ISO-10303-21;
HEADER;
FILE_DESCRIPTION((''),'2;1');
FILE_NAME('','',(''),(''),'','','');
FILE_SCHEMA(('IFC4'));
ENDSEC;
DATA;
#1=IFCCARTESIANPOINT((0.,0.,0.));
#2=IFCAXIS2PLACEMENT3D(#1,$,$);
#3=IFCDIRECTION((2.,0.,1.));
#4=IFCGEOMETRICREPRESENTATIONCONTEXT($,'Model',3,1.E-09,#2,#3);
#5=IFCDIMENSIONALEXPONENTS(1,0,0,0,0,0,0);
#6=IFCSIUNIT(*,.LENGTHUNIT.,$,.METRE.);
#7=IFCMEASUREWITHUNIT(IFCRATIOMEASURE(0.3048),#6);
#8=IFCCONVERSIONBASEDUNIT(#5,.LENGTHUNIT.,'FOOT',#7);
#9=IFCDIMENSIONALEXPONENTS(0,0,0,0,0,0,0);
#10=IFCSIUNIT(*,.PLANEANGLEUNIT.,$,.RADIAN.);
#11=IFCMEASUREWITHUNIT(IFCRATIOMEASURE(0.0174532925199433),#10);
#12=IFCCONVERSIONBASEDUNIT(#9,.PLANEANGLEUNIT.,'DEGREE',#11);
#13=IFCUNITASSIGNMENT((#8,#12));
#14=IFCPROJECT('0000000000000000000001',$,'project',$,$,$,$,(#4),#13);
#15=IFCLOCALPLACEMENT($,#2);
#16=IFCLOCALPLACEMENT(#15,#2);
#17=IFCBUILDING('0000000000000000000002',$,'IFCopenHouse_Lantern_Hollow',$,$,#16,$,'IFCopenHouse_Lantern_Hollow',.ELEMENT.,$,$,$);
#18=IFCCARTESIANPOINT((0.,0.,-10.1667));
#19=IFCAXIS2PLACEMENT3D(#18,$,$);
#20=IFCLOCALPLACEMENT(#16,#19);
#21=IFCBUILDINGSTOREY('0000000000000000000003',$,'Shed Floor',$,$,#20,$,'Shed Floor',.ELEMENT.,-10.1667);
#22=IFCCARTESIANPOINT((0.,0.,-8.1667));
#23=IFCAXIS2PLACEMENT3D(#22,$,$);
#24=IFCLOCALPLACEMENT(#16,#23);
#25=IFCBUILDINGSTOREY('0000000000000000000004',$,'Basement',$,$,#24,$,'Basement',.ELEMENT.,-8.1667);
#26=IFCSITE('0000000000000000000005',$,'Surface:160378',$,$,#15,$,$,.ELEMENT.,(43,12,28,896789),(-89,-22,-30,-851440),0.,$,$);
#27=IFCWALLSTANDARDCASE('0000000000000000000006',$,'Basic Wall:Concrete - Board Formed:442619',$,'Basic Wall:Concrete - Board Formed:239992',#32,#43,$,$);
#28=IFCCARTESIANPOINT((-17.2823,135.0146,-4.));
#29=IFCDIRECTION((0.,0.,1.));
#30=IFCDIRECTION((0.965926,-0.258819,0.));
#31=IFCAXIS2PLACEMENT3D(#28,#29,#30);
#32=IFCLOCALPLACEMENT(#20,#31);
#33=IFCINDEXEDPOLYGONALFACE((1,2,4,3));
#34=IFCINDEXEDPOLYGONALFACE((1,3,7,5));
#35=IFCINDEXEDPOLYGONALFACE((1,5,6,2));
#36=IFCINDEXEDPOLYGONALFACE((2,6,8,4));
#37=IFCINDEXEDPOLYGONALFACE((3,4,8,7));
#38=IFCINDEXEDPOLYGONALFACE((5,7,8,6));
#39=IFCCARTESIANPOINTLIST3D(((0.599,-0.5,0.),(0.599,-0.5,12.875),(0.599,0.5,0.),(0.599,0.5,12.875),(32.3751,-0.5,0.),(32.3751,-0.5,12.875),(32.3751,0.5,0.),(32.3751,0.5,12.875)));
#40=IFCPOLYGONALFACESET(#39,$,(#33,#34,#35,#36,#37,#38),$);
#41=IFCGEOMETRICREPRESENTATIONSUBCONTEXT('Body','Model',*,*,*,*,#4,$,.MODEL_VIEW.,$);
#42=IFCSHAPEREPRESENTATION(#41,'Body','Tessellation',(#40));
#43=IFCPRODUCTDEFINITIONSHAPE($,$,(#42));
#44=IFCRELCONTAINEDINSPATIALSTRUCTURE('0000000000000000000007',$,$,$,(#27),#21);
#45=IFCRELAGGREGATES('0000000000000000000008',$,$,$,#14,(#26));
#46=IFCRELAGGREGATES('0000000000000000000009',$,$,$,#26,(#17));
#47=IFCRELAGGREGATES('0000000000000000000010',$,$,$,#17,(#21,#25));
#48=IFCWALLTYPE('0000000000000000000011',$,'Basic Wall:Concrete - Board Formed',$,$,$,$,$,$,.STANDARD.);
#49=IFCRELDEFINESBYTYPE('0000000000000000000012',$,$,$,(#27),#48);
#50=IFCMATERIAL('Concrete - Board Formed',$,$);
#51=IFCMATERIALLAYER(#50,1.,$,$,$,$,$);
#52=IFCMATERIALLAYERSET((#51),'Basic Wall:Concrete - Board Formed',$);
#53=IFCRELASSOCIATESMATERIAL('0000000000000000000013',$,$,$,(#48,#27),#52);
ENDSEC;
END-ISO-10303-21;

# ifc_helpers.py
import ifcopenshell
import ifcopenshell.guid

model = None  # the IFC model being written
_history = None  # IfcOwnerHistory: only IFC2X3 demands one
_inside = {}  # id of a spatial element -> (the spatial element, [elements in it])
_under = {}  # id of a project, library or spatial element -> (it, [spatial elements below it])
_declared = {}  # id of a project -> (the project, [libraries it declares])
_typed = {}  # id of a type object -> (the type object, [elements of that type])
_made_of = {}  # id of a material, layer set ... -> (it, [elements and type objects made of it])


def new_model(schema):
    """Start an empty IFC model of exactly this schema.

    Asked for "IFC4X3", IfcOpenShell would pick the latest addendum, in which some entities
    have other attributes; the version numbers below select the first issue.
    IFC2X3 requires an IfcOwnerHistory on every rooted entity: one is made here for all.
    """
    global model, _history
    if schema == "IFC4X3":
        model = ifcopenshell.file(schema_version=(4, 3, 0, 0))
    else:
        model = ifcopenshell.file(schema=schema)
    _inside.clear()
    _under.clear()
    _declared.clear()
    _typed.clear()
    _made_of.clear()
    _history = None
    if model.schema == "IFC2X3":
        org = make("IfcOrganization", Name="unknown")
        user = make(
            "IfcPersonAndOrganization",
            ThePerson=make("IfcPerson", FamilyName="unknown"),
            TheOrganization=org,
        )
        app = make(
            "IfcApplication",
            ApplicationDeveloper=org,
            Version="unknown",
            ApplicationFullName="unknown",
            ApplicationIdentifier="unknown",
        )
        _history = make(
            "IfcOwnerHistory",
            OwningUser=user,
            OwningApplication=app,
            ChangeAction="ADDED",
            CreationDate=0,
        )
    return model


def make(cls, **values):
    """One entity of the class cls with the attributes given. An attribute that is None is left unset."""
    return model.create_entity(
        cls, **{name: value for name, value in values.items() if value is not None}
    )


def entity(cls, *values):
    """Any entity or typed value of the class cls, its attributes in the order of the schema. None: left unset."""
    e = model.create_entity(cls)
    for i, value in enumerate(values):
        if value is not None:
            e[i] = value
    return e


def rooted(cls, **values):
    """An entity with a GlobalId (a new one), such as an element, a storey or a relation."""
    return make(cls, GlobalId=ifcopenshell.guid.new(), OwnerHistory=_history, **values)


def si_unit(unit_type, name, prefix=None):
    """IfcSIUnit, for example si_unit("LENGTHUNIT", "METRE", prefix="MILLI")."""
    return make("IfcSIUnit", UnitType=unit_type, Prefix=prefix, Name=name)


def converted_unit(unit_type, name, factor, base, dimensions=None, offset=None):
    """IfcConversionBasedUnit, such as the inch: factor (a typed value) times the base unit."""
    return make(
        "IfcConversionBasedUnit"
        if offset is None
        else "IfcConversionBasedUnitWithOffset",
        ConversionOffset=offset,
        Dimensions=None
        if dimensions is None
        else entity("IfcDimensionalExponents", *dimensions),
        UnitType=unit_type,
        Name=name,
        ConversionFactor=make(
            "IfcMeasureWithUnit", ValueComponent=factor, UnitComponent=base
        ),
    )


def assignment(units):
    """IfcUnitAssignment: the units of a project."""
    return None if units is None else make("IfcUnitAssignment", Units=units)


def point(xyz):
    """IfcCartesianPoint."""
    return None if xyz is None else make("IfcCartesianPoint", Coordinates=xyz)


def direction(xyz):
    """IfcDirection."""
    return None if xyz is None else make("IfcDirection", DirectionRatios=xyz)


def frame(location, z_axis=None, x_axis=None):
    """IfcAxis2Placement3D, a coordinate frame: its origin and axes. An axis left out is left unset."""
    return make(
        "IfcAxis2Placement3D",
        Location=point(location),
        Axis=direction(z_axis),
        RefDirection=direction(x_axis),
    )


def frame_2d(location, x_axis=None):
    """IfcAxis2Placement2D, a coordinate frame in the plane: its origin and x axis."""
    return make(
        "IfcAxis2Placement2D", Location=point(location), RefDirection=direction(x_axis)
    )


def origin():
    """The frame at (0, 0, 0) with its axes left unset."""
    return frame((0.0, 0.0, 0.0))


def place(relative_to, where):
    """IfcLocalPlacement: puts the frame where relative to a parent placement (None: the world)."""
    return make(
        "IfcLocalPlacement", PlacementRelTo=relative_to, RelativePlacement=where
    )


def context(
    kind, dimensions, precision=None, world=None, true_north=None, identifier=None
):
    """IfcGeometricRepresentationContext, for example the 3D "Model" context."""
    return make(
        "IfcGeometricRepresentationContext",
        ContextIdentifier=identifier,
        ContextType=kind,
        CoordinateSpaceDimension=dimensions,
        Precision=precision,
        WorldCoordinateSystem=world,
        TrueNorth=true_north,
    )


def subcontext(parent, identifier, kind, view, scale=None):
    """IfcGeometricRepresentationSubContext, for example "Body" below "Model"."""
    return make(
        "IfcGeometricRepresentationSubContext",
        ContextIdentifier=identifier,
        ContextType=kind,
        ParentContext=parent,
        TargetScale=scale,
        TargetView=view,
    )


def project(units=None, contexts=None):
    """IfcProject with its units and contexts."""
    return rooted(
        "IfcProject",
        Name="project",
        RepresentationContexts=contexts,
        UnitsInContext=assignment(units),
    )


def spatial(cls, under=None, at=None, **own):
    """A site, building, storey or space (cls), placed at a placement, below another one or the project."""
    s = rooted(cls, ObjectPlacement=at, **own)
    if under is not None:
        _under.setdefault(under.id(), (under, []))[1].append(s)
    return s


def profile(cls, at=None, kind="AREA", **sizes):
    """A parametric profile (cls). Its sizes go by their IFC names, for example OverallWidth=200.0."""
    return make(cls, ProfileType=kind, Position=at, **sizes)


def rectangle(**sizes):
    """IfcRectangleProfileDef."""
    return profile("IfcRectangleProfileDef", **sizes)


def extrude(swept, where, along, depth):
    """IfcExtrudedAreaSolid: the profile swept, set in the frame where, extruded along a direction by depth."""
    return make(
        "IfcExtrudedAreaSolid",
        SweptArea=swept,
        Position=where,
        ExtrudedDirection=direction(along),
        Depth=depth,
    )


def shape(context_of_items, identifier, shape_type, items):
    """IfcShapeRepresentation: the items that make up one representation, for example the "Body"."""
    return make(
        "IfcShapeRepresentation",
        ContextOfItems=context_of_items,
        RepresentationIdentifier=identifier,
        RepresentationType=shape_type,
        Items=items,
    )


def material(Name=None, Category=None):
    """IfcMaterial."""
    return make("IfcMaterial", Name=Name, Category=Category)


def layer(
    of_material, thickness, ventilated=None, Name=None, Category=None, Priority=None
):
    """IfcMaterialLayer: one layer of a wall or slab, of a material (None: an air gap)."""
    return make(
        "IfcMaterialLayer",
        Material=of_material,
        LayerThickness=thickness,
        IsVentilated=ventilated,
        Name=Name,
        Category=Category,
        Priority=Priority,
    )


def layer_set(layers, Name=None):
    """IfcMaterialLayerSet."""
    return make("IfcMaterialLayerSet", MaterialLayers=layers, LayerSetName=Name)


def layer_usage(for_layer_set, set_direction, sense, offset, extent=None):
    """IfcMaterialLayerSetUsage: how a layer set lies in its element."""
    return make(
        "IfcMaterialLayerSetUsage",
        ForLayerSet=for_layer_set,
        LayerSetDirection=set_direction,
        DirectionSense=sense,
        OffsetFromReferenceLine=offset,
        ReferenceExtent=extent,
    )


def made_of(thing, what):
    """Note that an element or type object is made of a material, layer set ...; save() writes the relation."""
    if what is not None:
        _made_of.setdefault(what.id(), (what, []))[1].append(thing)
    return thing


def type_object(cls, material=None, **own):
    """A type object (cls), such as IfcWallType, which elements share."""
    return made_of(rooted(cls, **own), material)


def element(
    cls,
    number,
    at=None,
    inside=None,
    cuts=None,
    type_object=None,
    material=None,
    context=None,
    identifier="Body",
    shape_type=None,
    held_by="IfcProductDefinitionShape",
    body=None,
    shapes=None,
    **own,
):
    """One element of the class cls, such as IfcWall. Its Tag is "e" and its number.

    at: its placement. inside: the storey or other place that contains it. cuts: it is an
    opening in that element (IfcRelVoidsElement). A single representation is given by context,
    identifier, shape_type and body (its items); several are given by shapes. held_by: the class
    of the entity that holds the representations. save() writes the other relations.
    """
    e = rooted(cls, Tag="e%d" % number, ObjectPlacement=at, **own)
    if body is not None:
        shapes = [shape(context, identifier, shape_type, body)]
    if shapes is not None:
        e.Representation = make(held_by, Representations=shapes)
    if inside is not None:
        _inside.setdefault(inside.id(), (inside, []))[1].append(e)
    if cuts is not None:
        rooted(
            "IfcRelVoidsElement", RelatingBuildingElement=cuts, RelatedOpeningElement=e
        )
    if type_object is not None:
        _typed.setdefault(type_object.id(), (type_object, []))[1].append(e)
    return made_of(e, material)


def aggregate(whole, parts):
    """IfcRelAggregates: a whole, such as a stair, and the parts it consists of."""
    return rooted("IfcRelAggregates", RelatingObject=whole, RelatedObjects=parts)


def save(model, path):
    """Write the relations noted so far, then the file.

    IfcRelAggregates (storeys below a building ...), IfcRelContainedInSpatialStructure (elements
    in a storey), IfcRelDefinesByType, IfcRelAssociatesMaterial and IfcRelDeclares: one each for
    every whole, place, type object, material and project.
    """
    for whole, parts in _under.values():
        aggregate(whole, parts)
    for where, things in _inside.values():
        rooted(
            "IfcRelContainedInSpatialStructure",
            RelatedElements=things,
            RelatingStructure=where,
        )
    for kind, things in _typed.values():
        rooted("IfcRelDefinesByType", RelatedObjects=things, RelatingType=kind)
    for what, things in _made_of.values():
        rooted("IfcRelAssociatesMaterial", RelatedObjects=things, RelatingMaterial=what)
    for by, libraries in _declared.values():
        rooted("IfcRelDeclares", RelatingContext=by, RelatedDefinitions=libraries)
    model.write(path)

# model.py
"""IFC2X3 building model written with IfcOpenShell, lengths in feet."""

from ifc_helpers import new_model, entity, si_unit, converted_unit, direction, frame, frame_2d, origin, place, context, subcontext, project, spatial, rectangle, extrude, material, layer, layer_set, layer_usage, type_object, element, save


model = new_model("IFC2X3")

# Units and contexts
model_context = context("Model", 3, precision=1e-09, world=origin(), true_north=direction((2.0, 0.0, 1.0)))
body_context = subcontext(model_context, "Body", "Model", "MODEL_VIEW")
ifc_project = project(units=[converted_unit("LENGTHUNIT", "FOOT", entity("IfcRatioMeasure", 0.3048), si_unit("LENGTHUNIT", "METRE"), dimensions=[1, 0, 0, 0, 0, 0, 0]), converted_unit("PLANEANGLEUNIT", "DEGREE", entity("IfcRatioMeasure", 0.0174532925199433), si_unit("PLANEANGLEUNIT", "RADIAN"), dimensions=[0, 0, 0, 0, 0, 0, 0])], contexts=[model_context])

# Site, building, storey
site_placement = place(None, origin())
site = spatial("IfcSite", under=ifc_project, at=site_placement, Name="Surface:160378", CompositionType="ELEMENT", RefLatitude=(43, 12, 28, 896789), RefLongitude=(-89, -22, -30, -851440), RefElevation=0.0)
building_placement = place(site_placement, origin())
building = spatial("IfcBuilding", under=site, at=building_placement, Name="IFCopenHouse_Lantern_Hollow", LongName="IFCopenHouse_Lantern_Hollow", CompositionType="ELEMENT")
storey_1_placement = place(building_placement, frame((0.0, 0.0, -10.1667)))
storey_1 = spatial("IfcBuildingStorey", under=building, at=storey_1_placement, Name="Shed Floor", LongName="Shed Floor", CompositionType="ELEMENT", Elevation=-10.1667)

# Shared definitions
storey_2_placement = place(building_placement, frame((0.0, 0.0, -8.1667)))
storey_2 = spatial("IfcBuildingStorey", under=building, at=storey_2_placement, Name="Basement", LongName="Basement", CompositionType="ELEMENT", Elevation=-8.1667)

# Wall
ifc_material_1 = material(Name="Concrete - Board Formed")
ifc_layer_1 = layer(ifc_material_1, 1.0)
ifc_layer_set_1 = layer_set([ifc_layer_1], Name="Basic Wall:Concrete - Board Formed")
wall_type_1 = type_object("IfcWallType", Name="Basic Wall:Concrete - Board Formed", PredefinedType="STANDARD", material=ifc_layer_set_1)
ifc_layer_usage_1 = layer_usage(ifc_layer_set_1, "AXIS2", "NEGATIVE", 0.5)
wall_1_placement = place(storey_1_placement, frame((-17.2823, 135.0146, -4.0), z_axis=(0.0, 0.0, 1.0), x_axis=(0.965926, -0.258819, 0.0)))
element("IfcWallStandardCase", 1, at=wall_1_placement, inside=storey_1, type_object=wall_type_1, material=ifc_layer_usage_1, Name="Basic Wall:Concrete - Board Formed:442619", ObjectType="Basic Wall:Concrete - Board Formed:239992", context=body_context, shape_type="SweptSolid", body=[
    extrude(rectangle(XDim=31.7761, YDim=1.0, at=frame_2d((16.487, 0.0), x_axis=(-1.0, 0.0))), origin(), (0.0, 0.0, 1.0), 12.875),
])

save(model, "model.ifc")
